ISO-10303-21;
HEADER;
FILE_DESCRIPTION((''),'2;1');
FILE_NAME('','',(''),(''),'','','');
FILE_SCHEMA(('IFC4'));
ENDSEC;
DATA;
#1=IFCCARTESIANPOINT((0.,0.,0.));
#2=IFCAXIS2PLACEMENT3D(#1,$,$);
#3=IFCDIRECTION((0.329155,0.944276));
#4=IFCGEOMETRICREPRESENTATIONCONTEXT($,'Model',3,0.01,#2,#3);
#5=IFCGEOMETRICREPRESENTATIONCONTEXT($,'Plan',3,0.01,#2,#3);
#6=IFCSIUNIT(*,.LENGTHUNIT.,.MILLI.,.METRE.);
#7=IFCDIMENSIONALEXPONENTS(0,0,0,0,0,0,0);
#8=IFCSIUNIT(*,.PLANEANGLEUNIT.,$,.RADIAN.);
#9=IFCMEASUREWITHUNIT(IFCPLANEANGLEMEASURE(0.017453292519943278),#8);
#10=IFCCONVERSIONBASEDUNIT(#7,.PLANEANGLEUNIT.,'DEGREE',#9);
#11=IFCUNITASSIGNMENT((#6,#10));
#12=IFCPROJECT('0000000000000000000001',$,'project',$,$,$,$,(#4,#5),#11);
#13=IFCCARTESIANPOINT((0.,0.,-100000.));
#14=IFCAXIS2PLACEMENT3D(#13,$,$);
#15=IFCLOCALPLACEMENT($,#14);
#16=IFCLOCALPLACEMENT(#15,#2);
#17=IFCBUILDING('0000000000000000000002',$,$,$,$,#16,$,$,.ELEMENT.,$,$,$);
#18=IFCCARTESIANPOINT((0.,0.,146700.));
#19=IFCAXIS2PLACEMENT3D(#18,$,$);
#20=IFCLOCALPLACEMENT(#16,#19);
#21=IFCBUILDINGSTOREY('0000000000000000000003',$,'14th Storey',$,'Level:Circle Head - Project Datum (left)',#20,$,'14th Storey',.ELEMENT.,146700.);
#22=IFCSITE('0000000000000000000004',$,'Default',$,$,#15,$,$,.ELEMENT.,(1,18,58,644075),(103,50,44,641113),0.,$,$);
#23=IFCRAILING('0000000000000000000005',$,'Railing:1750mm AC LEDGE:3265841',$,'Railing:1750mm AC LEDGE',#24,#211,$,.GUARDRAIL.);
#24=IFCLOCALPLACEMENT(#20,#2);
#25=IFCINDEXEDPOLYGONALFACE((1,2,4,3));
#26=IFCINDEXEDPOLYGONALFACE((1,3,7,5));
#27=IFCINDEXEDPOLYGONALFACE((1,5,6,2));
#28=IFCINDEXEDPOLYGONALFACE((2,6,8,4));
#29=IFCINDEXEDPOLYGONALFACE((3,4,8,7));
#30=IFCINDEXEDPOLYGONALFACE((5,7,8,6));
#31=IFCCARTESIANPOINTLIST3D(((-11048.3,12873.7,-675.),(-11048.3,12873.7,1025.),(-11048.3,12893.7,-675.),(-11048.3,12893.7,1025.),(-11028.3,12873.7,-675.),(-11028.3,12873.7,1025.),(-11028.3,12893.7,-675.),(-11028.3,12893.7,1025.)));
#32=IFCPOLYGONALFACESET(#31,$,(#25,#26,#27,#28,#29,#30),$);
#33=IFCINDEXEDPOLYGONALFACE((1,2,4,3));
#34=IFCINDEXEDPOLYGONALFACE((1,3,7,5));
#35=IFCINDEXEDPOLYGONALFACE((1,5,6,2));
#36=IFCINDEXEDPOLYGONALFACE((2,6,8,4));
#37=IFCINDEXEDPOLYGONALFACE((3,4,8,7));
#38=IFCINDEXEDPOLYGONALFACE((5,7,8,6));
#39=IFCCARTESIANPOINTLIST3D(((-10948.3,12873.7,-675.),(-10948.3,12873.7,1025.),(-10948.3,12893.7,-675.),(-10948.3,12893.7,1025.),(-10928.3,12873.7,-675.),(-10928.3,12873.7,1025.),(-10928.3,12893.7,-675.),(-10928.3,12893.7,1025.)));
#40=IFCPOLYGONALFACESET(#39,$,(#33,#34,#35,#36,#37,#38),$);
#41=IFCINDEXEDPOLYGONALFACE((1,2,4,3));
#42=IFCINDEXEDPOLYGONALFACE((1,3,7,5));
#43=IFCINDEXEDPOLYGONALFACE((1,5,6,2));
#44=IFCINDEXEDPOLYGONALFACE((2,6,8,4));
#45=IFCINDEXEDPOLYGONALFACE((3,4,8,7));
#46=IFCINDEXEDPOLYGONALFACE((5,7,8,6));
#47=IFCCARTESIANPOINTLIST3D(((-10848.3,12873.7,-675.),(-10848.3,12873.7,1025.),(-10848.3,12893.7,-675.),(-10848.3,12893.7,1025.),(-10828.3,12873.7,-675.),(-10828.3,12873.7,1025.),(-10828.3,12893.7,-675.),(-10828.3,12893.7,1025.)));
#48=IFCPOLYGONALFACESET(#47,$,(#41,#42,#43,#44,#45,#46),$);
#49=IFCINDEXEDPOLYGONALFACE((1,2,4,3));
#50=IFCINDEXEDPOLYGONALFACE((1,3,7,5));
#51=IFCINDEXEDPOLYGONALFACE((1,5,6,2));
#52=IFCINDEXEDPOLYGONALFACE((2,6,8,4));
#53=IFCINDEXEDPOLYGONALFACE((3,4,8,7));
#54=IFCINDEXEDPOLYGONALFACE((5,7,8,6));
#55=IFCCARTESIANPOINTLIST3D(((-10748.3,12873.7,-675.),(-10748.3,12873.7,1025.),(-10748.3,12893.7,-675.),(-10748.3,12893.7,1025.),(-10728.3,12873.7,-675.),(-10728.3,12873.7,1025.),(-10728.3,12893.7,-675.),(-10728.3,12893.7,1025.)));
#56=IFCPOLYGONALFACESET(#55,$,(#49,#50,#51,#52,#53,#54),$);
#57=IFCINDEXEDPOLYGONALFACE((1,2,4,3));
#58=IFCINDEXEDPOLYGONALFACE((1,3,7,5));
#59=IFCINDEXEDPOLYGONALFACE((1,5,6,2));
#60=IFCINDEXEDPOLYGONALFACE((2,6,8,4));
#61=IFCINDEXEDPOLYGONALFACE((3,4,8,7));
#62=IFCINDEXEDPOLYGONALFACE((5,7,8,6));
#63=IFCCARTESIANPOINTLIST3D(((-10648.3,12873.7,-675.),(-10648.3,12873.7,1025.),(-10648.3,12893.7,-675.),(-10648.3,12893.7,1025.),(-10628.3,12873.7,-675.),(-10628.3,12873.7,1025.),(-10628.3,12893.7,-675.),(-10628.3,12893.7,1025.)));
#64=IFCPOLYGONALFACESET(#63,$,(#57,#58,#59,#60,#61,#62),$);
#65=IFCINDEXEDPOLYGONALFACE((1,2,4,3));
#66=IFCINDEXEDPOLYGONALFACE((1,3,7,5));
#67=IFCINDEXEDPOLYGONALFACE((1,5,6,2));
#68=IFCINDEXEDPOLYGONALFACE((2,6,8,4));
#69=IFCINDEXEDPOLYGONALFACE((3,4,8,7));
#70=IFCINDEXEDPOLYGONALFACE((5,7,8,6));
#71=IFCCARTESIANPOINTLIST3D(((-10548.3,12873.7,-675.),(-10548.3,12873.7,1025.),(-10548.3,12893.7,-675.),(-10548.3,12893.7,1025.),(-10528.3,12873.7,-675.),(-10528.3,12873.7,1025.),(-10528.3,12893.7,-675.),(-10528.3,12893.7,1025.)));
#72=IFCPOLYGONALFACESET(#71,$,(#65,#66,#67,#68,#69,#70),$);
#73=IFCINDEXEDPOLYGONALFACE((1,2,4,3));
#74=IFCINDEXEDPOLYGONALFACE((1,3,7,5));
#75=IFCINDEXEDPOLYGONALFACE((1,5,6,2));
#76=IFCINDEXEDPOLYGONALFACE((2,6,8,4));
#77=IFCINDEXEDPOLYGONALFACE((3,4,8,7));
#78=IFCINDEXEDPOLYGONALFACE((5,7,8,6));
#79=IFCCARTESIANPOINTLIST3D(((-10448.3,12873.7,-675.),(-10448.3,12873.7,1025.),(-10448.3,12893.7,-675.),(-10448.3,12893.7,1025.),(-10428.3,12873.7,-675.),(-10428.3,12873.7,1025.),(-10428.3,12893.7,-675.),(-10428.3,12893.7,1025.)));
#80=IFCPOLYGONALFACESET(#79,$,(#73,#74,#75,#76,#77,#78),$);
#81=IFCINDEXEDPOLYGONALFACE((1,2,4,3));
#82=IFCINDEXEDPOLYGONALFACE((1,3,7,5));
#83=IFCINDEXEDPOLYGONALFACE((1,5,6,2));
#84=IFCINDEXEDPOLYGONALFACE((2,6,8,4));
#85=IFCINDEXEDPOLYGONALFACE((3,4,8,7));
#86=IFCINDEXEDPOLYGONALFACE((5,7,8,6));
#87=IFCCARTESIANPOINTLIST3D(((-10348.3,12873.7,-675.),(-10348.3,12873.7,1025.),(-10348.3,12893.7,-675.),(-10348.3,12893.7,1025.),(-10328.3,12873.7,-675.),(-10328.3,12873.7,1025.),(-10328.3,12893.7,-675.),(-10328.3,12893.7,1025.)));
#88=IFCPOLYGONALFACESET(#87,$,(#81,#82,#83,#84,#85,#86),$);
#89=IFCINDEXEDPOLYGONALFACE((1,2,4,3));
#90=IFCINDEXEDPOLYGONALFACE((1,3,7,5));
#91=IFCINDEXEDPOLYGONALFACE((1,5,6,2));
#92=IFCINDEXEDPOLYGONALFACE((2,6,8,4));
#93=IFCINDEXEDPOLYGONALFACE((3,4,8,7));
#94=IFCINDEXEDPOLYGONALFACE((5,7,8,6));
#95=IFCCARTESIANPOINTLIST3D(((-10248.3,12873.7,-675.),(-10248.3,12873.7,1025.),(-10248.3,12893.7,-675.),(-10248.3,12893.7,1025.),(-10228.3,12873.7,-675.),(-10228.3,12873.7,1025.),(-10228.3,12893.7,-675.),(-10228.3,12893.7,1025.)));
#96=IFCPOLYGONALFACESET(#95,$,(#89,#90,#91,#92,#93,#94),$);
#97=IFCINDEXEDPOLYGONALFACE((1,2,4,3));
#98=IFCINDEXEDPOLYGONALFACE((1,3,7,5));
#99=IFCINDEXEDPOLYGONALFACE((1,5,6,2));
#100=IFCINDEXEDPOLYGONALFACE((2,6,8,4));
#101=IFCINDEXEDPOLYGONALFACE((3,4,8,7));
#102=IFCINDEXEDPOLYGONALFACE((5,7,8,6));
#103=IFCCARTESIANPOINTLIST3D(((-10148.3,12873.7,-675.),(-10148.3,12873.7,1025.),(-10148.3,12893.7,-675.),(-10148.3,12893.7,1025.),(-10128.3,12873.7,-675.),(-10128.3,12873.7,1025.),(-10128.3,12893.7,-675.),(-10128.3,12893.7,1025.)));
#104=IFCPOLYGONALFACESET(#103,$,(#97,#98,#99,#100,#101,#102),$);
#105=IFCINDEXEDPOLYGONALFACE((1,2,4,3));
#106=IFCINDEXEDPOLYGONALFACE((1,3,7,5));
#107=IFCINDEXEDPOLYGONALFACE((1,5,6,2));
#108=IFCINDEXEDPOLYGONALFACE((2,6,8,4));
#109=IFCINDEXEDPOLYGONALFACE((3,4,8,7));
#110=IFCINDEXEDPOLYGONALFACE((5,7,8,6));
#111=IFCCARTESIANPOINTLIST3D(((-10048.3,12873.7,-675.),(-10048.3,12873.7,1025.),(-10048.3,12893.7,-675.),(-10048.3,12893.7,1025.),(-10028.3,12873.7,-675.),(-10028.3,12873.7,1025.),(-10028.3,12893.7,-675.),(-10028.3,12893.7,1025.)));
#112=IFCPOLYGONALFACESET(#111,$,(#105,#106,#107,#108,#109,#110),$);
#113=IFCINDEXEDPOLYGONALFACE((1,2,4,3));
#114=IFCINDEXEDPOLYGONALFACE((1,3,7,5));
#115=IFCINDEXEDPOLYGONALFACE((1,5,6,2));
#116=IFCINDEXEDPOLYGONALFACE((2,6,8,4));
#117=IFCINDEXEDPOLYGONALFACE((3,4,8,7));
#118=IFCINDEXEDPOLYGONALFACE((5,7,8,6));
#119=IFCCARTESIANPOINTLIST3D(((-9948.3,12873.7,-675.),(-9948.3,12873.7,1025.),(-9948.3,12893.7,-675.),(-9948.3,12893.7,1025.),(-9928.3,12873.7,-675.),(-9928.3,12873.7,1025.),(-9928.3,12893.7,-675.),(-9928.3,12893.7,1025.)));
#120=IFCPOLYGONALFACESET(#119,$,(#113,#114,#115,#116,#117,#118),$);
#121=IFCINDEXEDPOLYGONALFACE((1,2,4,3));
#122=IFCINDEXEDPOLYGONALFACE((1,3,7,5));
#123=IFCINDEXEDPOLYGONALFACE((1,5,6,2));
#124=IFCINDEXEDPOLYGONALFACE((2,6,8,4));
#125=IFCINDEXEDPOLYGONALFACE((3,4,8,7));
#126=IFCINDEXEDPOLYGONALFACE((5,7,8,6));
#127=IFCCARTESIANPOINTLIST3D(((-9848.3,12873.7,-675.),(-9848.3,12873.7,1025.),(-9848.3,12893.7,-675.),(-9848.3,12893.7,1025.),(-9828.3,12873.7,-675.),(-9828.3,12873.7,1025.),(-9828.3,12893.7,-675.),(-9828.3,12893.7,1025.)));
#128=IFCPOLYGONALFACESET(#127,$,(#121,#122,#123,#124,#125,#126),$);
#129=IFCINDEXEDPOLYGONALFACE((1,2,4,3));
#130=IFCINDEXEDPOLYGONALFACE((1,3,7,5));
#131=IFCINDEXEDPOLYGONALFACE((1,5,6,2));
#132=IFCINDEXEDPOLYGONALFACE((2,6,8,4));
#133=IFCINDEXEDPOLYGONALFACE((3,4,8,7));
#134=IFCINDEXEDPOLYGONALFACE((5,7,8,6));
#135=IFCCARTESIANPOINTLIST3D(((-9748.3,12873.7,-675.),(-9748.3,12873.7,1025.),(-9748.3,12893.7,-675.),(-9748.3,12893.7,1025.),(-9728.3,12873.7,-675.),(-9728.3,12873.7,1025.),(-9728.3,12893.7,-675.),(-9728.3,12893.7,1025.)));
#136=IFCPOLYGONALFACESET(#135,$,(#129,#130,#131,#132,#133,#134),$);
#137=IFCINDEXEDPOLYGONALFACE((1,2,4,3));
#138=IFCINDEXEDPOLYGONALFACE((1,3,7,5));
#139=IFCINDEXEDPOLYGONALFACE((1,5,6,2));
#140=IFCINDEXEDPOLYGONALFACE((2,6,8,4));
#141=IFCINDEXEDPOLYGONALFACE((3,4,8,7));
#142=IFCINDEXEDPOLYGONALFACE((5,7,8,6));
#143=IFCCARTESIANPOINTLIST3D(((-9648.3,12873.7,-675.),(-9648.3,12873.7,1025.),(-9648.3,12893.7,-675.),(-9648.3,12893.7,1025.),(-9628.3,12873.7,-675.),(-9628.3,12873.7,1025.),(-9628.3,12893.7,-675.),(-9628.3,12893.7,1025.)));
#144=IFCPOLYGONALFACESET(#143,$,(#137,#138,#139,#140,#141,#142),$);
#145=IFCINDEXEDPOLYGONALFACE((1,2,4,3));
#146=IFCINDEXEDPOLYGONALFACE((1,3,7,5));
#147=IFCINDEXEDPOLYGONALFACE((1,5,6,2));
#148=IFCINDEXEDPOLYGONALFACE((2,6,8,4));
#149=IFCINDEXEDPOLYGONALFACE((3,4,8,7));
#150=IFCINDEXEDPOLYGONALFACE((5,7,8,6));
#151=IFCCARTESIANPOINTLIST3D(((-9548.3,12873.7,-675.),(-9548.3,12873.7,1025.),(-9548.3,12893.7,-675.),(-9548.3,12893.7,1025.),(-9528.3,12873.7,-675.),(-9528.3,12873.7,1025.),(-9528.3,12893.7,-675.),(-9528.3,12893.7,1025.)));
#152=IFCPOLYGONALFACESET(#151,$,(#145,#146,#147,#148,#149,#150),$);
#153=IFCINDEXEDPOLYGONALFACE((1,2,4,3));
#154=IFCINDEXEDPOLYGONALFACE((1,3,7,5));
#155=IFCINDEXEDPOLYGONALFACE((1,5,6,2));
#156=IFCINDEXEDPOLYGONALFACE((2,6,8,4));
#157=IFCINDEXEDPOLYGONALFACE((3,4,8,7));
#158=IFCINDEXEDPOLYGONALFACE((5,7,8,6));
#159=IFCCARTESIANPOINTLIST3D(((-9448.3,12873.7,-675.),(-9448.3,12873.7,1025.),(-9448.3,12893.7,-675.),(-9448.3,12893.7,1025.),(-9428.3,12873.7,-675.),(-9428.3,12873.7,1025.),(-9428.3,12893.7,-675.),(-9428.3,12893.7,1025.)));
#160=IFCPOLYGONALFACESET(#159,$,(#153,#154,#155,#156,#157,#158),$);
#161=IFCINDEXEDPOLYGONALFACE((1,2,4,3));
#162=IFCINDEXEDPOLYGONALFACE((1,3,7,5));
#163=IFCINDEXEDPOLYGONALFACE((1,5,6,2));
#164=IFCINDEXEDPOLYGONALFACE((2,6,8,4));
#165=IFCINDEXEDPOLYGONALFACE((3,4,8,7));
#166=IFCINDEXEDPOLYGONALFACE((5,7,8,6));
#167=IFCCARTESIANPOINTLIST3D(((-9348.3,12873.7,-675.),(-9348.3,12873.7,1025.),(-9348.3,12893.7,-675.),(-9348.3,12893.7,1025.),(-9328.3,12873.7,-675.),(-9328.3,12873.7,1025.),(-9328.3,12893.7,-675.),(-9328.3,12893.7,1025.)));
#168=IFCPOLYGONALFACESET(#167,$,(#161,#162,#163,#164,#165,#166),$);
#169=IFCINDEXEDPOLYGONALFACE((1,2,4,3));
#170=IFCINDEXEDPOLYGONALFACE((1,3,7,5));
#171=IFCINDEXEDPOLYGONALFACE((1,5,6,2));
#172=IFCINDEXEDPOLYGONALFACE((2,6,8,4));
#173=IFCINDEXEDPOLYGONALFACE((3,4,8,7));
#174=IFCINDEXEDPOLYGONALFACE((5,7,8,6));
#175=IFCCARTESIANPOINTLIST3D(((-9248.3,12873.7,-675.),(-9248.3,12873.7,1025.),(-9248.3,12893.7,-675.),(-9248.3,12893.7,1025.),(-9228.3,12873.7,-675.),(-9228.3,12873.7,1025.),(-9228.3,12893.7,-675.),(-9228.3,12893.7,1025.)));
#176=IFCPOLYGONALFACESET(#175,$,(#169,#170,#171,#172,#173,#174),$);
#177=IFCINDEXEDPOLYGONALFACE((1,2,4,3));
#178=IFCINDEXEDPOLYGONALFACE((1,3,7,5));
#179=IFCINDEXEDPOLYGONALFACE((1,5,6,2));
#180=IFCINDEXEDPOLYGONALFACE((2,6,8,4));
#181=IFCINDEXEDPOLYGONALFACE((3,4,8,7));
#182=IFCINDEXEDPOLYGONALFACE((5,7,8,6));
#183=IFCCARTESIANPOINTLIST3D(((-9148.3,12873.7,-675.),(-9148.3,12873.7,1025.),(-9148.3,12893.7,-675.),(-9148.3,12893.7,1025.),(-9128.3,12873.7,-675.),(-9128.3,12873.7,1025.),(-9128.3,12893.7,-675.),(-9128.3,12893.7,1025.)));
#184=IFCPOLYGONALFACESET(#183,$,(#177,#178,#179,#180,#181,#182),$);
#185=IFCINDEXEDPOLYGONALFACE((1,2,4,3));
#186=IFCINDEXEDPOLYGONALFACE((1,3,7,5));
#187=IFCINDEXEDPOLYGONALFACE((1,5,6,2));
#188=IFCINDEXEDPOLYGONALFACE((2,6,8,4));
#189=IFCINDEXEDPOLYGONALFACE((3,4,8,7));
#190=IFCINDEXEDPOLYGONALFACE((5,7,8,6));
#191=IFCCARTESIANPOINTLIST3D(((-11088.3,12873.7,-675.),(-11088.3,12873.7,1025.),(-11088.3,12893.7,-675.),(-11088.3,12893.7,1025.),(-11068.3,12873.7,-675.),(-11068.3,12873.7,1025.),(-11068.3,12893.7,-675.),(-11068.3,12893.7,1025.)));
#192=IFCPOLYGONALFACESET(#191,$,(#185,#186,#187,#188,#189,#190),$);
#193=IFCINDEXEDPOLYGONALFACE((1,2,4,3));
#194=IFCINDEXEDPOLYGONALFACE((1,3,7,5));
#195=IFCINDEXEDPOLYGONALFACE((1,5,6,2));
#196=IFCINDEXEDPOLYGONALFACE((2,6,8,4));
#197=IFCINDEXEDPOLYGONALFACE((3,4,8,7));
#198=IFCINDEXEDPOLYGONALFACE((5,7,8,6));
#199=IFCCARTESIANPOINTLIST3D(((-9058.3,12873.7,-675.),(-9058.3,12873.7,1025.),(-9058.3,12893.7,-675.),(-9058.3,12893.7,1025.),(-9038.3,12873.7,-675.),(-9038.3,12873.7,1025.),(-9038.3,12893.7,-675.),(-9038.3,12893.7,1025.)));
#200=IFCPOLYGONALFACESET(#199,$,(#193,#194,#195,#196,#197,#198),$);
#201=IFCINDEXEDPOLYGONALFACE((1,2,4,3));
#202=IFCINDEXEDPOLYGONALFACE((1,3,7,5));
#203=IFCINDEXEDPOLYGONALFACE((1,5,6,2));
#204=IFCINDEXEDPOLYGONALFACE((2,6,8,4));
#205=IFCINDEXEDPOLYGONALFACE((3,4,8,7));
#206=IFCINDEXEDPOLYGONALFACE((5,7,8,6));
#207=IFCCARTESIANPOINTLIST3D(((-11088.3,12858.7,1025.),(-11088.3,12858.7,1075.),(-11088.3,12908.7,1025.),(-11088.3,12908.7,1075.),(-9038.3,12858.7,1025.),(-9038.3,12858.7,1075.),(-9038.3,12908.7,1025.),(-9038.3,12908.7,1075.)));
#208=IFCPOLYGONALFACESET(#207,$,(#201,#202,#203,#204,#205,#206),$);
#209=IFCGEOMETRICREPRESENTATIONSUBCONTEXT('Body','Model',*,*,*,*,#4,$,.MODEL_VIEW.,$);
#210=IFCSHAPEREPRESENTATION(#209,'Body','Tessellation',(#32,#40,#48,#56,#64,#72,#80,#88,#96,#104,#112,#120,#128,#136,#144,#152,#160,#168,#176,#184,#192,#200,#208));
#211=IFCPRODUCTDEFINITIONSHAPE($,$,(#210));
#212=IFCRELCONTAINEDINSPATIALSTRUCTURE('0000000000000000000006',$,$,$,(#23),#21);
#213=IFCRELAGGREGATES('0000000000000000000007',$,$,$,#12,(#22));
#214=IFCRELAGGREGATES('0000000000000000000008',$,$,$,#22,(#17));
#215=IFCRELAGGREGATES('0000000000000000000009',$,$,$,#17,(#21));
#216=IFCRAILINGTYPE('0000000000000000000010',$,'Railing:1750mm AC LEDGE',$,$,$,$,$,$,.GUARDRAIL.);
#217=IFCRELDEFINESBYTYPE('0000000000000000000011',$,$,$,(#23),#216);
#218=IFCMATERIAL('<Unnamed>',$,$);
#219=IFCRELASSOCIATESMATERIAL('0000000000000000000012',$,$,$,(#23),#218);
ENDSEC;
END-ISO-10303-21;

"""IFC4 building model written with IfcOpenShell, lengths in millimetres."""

from ifc_helpers import new_model, entity, si_unit, converted_unit, direction, frame, origin, place, context, subcontext, project, spatial, indexed_curve, outline, extrude, material, type_object, element, save


model = new_model("IFC4")

# Units and contexts
model_context = context("Model", 3, precision=0.01, world=origin(), true_north=direction((0.329155, 0.944276)))
plan_context = context("Plan", 3, precision=0.01, world=origin(), true_north=direction((0.329155, 0.944276)))
body_context = subcontext(model_context, "Body", "Model", "MODEL_VIEW")
ifc_project = project(units=[si_unit("LENGTHUNIT", "METRE", prefix="MILLI"), converted_unit("PLANEANGLEUNIT", "DEGREE", entity("IfcPlaneAngleMeasure", 0.017453292519943278), si_unit("PLANEANGLEUNIT", "RADIAN"), dimensions=[0, 0, 0, 0, 0, 0, 0])], contexts=[model_context, plan_context])

# Site, building, storey
site_placement = place(None, frame((0.0, 0.0, -100000.0)))
site = spatial("IfcSite", under=ifc_project, at=site_placement, Name="Default", CompositionType="ELEMENT", RefLatitude=(1, 18, 58, 644075), RefLongitude=(103, 50, 44, 641113), RefElevation=0.0)
building_placement = place(site_placement, origin())
building = spatial("IfcBuilding", under=site, at=building_placement, CompositionType="ELEMENT")
storey_placement = place(building_placement, frame((0.0, 0.0, 146700.0)))
storey = spatial("IfcBuildingStorey", under=building, at=storey_placement, Name="14th Storey", ObjectType="Level:Circle Head - Project Datum (left)", LongName="14th Storey", CompositionType="ELEMENT", Elevation=146700.0)

# Railing
ifc_material_1 = material(Name="<Unnamed>")
railing_type = type_object("IfcRailingType", Name="Railing:1750mm AC LEDGE", PredefinedType="GUARDRAIL")
railing_placement = place(storey_placement, frame((-11088.3, 12858.7, -675.0)))
element("IfcRailing", 1, at=railing_placement, inside=storey, type_object=railing_type, material=ifc_material_1, Name="Railing:1750mm AC LEDGE:3265841", ObjectType="Railing:1750mm AC LEDGE", PredefinedType="GUARDRAIL", context=body_context, shape_type="SweptSolid", body=[
    extrude(outline(indexed_curve([(-10.0, -10.0), (10.0, -10.0), (10.0, 10.0), (-10.0, 10.0), (-10.0, -10.0)], self_intersect=False)), frame((50.0, 25.0, 0.0), z_axis=(0.0, 0.0, 1.0), x_axis=(-1.0, 0.0, 0.0)), (0.0, 0.0, 1.0), 1700.0),
    extrude(outline(indexed_curve([(-10.0, -10.0), (10.0, -10.0), (10.0, 10.0), (-10.0, 10.0), (-10.0, -10.0)], self_intersect=False)), frame((150.0, 25.0, 0.0), z_axis=(0.0, 0.0, 1.0), x_axis=(-1.0, 0.0, 0.0)), (0.0, 0.0, 1.0), 1700.0),
    extrude(outline(indexed_curve([(-10.0, -10.0), (10.0, -10.0), (10.0, 10.0), (-10.0, 10.0), (-10.0, -10.0)], self_intersect=False)), frame((250.0, 25.0, 0.0), z_axis=(0.0, 0.0, 1.0), x_axis=(-1.0, 0.0, 0.0)), (0.0, 0.0, 1.0), 1700.0),
    extrude(outline(indexed_curve([(-10.0, -10.0), (10.0, -10.0), (10.0, 10.0), (-10.0, 10.0), (-10.0, -10.0)], self_intersect=False)), frame((350.0, 25.0, 0.0), z_axis=(0.0, 0.0, 1.0), x_axis=(-1.0, 0.0, 0.0)), (0.0, 0.0, 1.0), 1700.0),
    extrude(outline(indexed_curve([(-10.0, -10.0), (10.0, -10.0), (10.0, 10.0), (-10.0, 10.0), (-10.0, -10.0)], self_intersect=False)), frame((450.0, 25.0, 0.0), z_axis=(0.0, 0.0, 1.0), x_axis=(-1.0, 0.0, 0.0)), (0.0, 0.0, 1.0), 1700.0),
    extrude(outline(indexed_curve([(-10.0, -10.0), (10.0, -10.0), (10.0, 10.0), (-10.0, 10.0), (-10.0, -10.0)], self_intersect=False)), frame((550.0, 25.0, 0.0), z_axis=(0.0, 0.0, 1.0), x_axis=(-1.0, 0.0, 0.0)), (0.0, 0.0, 1.0), 1700.0),
    extrude(outline(indexed_curve([(-10.0, -10.0), (10.0, -10.0), (10.0, 10.0), (-10.0, 10.0), (-10.0, -10.0)], self_intersect=False)), frame((650.0, 25.0, 0.0), z_axis=(0.0, 0.0, 1.0), x_axis=(-1.0, 0.0, 0.0)), (0.0, 0.0, 1.0), 1700.0),
    extrude(outline(indexed_curve([(-10.0, -10.0), (10.0, -10.0), (10.0, 10.0), (-10.0, 10.0), (-10.0, -10.0)], self_intersect=False)), frame((750.0, 25.0, 0.0), z_axis=(0.0, 0.0, 1.0), x_axis=(-1.0, 0.0, 0.0)), (0.0, 0.0, 1.0), 1700.0),
    extrude(outline(indexed_curve([(-10.0, -10.0), (10.0, -10.0), (10.0, 10.0), (-10.0, 10.0), (-10.0, -10.0)], self_intersect=False)), frame((850.0, 25.0, 0.0), z_axis=(0.0, 0.0, 1.0), x_axis=(-1.0, 0.0, 0.0)), (0.0, 0.0, 1.0), 1700.0),
    extrude(outline(indexed_curve([(-10.0, -10.0), (10.0, -10.0), (10.0, 10.0), (-10.0, 10.0), (-10.0, -10.0)], self_intersect=False)), frame((950.0, 25.0, 0.0), z_axis=(0.0, 0.0, 1.0), x_axis=(-1.0, 0.0, 0.0)), (0.0, 0.0, 1.0), 1700.0),
    extrude(outline(indexed_curve([(-10.0, -10.0), (10.0, -10.0), (10.0, 10.0), (-10.0, 10.0), (-10.0, -10.0)], self_intersect=False)), frame((1050.0, 25.0, 0.0), z_axis=(0.0, 0.0, 1.0), x_axis=(-1.0, 0.0, 0.0)), (0.0, 0.0, 1.0), 1700.0),
    extrude(outline(indexed_curve([(-10.0, -10.0), (10.0, -10.0), (10.0, 10.0), (-10.0, 10.0), (-10.0, -10.0)], self_intersect=False)), frame((1150.0, 25.0, 0.0), z_axis=(0.0, 0.0, 1.0), x_axis=(-1.0, 0.0, 0.0)), (0.0, 0.0, 1.0), 1700.0),
    extrude(outline(indexed_curve([(-10.0, -10.0), (10.0, -10.0), (10.0, 10.0), (-10.0, 10.0), (-10.0, -10.0)], self_intersect=False)), frame((1250.0, 25.0, 0.0), z_axis=(0.0, 0.0, 1.0), x_axis=(-1.0, 0.0, 0.0)), (0.0, 0.0, 1.0), 1700.0),
    extrude(outline(indexed_curve([(-10.0, -10.0), (10.0, -10.0), (10.0, 10.0), (-10.0, 10.0), (-10.0, -10.0)], self_intersect=False)), frame((1350.0, 25.0, 0.0), z_axis=(0.0, 0.0, 1.0), x_axis=(-1.0, 0.0, 0.0)), (0.0, 0.0, 1.0), 1700.0),
    extrude(outline(indexed_curve([(-10.0, -10.0), (10.0, -10.0), (10.0, 10.0), (-10.0, 10.0), (-10.0, -10.0)], self_intersect=False)), frame((1450.0, 25.0, 0.0), z_axis=(0.0, 0.0, 1.0), x_axis=(-1.0, 0.0, 0.0)), (0.0, 0.0, 1.0), 1700.0),
    extrude(outline(indexed_curve([(-10.0, -10.0), (10.0, -10.0), (10.0, 10.0), (-10.0, 10.0), (-10.0, -10.0)], self_intersect=False)), frame((1550.0, 25.0, 0.0), z_axis=(0.0, 0.0, 1.0), x_axis=(-1.0, 0.0, 0.0)), (0.0, 0.0, 1.0), 1700.0),
    extrude(outline(indexed_curve([(-10.0, -10.0), (10.0, -10.0), (10.0, 10.0), (-10.0, 10.0), (-10.0, -10.0)], self_intersect=False)), frame((1650.0, 25.0, 0.0), z_axis=(0.0, 0.0, 1.0), x_axis=(-1.0, 0.0, 0.0)), (0.0, 0.0, 1.0), 1700.0),
    extrude(outline(indexed_curve([(-10.0, -10.0), (10.0, -10.0), (10.0, 10.0), (-10.0, 10.0), (-10.0, -10.0)], self_intersect=False)), frame((1750.0, 25.0, 0.0), z_axis=(0.0, 0.0, 1.0), x_axis=(-1.0, 0.0, 0.0)), (0.0, 0.0, 1.0), 1700.0),
    extrude(outline(indexed_curve([(-10.0, -10.0), (10.0, -10.0), (10.0, 10.0), (-10.0, 10.0), (-10.0, -10.0)], self_intersect=False)), frame((1850.0, 25.0, 0.0), z_axis=(0.0, 0.0, 1.0), x_axis=(-1.0, 0.0, 0.0)), (0.0, 0.0, 1.0), 1700.0),
    extrude(outline(indexed_curve([(-10.0, -10.0), (10.0, -10.0), (10.0, 10.0), (-10.0, 10.0), (-10.0, -10.0)], self_intersect=False)), frame((1950.0, 25.0, 0.0), z_axis=(0.0, 0.0, 1.0), x_axis=(-1.0, 0.0, 0.0)), (0.0, 0.0, 1.0), 1700.0),
    extrude(outline(indexed_curve([(-10.0, -10.0), (10.0, -10.0), (10.0, 10.0), (-10.0, 10.0), (-10.0, -10.0)], self_intersect=False)), frame((10.0, 25.0, 0.0), z_axis=(0.0, 0.0, 1.0), x_axis=(-1.0, 0.0, 0.0)), (0.0, 0.0, 1.0), 1700.0),
    extrude(outline(indexed_curve([(-10.0, -10.0), (10.0, -10.0), (10.0, 10.0), (-10.0, 10.0), (-10.0, -10.0)], self_intersect=False)), frame((2040.0, 25.0, 0.0), z_axis=(0.0, 0.0, 1.0), x_axis=(-1.0, 0.0, 0.0)), (0.0, 0.0, 1.0), 1700.0),
    extrude(outline(indexed_curve([(-1025.0, -25.0), (1025.0, -25.0), (1025.0, 25.0), (-1025.0, 25.0), (-1025.0, -25.0)], self_intersect=False)), frame((1025.0, 25.0, 1700.0), z_axis=(0.0, 0.0, 1.0), x_axis=(-1.0, 0.0, 0.0)), (0.0, 0.0, 1.0), 50.0),
])

save(model, "model.ifc")
